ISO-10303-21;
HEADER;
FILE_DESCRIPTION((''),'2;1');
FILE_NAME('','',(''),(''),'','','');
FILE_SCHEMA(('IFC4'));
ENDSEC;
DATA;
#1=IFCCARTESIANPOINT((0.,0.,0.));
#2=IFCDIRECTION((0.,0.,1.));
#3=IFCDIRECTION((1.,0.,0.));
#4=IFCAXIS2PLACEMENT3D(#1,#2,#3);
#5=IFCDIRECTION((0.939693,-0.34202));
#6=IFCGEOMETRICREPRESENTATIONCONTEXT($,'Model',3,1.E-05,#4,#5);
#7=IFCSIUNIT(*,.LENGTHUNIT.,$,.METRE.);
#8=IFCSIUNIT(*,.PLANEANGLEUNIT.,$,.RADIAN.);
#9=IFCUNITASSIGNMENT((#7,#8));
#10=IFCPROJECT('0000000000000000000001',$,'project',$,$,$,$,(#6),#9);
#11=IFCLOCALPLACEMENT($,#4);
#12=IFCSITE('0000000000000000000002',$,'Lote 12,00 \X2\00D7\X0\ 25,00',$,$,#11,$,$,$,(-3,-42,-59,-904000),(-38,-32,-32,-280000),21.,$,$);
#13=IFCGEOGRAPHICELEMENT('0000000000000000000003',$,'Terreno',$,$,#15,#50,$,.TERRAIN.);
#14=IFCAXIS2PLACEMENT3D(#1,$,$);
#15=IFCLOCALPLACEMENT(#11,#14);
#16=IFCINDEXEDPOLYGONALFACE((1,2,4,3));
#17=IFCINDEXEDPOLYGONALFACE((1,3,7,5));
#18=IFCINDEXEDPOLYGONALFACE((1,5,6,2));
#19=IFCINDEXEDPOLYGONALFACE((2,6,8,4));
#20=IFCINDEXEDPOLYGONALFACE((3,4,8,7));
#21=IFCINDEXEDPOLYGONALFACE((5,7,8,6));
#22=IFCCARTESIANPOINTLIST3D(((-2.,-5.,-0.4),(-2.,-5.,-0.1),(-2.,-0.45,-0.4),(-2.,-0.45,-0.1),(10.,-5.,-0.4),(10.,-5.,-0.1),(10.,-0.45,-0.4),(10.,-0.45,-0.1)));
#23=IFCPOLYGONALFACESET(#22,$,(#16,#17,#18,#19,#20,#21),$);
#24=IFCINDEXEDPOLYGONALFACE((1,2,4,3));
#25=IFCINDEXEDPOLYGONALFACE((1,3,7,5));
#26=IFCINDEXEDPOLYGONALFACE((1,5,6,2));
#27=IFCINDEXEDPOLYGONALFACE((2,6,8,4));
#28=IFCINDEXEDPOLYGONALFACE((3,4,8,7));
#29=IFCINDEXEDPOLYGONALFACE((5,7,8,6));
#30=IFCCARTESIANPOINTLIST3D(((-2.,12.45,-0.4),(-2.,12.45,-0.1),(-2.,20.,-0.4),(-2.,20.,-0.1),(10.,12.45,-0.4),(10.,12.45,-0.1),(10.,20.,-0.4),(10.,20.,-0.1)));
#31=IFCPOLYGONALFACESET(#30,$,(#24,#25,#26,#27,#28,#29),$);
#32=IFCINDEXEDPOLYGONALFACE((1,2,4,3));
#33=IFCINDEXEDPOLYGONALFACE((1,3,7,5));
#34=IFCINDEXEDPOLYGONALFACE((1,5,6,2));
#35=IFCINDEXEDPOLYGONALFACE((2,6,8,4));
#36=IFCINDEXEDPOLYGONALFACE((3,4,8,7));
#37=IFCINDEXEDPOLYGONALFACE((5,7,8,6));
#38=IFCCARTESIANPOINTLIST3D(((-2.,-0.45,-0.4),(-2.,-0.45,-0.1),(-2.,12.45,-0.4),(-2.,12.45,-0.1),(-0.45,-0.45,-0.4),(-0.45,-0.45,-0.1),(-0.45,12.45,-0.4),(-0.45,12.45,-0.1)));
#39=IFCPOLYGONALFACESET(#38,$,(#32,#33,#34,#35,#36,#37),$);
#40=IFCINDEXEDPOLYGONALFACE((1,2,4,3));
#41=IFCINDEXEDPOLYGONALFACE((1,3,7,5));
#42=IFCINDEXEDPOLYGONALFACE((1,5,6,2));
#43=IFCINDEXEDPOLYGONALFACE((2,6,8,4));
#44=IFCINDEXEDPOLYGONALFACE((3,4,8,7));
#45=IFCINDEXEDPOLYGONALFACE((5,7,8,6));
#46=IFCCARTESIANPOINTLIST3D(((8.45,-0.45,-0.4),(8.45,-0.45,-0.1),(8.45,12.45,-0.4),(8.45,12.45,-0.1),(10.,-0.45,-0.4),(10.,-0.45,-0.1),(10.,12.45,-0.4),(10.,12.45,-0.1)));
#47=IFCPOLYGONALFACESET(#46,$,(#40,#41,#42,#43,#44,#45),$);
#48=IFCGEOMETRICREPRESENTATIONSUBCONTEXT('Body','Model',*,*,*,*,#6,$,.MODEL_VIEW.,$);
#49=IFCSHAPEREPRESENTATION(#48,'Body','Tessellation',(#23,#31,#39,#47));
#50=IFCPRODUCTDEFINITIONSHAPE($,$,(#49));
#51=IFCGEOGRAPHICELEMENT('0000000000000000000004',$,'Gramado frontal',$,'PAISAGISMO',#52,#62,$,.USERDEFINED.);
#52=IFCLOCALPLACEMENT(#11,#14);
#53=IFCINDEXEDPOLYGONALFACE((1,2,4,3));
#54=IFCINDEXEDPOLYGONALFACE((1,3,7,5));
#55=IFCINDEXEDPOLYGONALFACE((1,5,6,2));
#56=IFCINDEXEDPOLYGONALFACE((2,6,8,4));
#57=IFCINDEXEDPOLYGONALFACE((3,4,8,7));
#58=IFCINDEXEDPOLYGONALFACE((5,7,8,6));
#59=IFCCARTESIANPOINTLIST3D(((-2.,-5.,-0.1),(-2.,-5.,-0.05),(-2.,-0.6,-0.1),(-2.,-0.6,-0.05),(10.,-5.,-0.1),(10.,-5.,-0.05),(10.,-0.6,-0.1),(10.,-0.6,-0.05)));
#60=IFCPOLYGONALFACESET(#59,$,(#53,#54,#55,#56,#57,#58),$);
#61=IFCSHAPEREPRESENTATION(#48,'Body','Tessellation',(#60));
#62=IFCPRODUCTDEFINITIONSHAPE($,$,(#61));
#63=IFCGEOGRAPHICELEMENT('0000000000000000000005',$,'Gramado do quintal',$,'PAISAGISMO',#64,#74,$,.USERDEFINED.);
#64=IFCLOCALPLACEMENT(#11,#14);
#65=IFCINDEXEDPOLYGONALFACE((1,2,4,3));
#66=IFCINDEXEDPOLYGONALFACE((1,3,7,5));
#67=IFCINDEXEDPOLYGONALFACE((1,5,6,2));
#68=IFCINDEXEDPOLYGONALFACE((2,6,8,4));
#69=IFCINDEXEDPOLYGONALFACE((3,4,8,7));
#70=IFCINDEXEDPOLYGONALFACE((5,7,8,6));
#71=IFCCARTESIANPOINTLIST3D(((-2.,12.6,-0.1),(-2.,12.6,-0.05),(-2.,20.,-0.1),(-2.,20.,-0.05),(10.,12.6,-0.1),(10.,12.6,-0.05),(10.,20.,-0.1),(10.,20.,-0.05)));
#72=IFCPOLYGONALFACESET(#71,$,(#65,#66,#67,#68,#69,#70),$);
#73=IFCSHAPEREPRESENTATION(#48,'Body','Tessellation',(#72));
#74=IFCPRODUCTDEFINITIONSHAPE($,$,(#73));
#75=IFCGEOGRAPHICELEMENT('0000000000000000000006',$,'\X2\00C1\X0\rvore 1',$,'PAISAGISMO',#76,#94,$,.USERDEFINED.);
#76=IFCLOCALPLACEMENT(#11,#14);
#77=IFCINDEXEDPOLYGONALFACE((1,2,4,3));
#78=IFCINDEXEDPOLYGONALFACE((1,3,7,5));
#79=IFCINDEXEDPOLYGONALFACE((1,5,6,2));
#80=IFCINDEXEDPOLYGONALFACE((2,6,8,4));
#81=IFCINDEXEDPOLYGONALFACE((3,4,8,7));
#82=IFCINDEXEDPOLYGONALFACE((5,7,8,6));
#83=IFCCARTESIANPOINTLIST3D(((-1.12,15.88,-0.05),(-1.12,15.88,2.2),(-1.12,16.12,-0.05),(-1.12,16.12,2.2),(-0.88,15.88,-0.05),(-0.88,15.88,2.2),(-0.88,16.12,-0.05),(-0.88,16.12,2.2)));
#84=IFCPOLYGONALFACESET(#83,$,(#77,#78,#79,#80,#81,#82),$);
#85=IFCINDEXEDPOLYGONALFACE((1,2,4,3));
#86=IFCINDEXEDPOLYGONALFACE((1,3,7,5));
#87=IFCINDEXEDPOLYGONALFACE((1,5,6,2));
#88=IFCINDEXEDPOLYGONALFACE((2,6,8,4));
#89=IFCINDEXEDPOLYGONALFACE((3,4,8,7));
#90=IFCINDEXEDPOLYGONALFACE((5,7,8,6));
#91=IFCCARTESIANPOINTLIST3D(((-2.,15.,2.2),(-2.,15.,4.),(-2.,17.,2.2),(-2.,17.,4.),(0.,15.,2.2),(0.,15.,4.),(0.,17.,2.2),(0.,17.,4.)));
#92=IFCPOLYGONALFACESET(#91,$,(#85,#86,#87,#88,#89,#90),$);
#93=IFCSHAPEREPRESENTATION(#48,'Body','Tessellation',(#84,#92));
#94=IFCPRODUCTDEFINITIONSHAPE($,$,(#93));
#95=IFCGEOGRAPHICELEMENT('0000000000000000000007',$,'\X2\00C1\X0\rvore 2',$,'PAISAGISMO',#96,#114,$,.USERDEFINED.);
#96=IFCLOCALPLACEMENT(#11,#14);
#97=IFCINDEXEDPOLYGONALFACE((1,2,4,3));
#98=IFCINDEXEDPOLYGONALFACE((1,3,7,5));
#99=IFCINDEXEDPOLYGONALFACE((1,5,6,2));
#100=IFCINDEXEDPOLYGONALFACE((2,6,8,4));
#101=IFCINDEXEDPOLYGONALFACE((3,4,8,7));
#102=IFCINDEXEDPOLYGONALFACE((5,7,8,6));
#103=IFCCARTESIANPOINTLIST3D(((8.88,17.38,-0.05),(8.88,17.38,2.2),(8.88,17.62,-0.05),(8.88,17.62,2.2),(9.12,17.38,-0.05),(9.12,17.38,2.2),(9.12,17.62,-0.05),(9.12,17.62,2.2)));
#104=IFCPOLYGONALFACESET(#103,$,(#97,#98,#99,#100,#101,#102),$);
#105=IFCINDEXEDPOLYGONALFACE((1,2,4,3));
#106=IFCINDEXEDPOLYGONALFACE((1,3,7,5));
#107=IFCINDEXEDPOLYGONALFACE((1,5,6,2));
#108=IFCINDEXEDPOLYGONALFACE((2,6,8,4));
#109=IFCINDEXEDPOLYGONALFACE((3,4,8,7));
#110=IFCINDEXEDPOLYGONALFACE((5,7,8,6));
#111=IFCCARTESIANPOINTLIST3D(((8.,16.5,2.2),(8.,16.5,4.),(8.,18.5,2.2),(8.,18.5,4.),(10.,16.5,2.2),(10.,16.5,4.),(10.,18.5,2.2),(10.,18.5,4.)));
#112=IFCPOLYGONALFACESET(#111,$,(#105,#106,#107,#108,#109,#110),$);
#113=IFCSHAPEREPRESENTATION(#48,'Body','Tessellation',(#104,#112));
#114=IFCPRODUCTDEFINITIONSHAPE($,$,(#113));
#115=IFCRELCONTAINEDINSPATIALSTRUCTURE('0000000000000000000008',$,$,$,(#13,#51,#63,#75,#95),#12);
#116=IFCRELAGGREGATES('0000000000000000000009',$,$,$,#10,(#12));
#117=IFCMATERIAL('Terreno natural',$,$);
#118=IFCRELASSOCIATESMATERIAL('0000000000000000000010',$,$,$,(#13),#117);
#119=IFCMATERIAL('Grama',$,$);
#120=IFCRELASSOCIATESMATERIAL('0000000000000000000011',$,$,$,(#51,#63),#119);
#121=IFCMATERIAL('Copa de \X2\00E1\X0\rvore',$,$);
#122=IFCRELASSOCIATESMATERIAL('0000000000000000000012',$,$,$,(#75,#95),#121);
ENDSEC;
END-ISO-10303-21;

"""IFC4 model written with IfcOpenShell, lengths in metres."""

from ifc_helpers import new_model, si_unit, direction, frame, origin_with_axes, place, context, subcontext, project, spatial, line, indexed_curve, outline, extrude, material, element, save


model = new_model("IFC4")

# Units and contexts
model_context = context("Model", 3, precision=1e-05, world=origin_with_axes(), true_north=direction((0.939693, -0.34202)))
body_context = subcontext(model_context, "Body", "Model", "MODEL_VIEW")
ifc_project = project(units=[si_unit("LENGTHUNIT", "METRE"), si_unit("PLANEANGLEUNIT", "RADIAN")], contexts=[model_context])

# Site
site_placement = place(None, origin_with_axes())
site = spatial("IfcSite", under=ifc_project, at=site_placement, Name="Lote 12,00 × 25,00", RefLatitude=(-3, -42, -59, -904000), RefLongitude=(-38, -32, -32, -280000), RefElevation=21.0)

# Geographic elements
ifc_material_1 = material(Name="Terreno natural")
geographic_element_1_placement = place(site_placement, origin_with_axes())
element("IfcGeographicElement", 1, at=geographic_element_1_placement, inside=site, material=ifc_material_1, Name="Terreno", PredefinedType="TERRAIN", context=body_context, shape_type="SweptSolid", body=[
    extrude(outline(indexed_curve([(-2.0, -5.0), (10.0, -5.0), (10.0, -0.45), (-2.0, -0.45)], segments=[line(1, 2, 3, 4, 1)])), frame((0.0, 0.0, -0.4), z_axis=(0.0, 0.0, 1.0), x_axis=(1.0, 0.0, 0.0)), (0.0, 0.0, 1.0), 0.3),
    extrude(outline(indexed_curve([(-2.0, 12.45), (10.0, 12.45), (10.0, 20.0), (-2.0, 20.0)], segments=[line(1, 2, 3, 4, 1)])), frame((0.0, 0.0, -0.4), z_axis=(0.0, 0.0, 1.0), x_axis=(1.0, 0.0, 0.0)), (0.0, 0.0, 1.0), 0.3),
    extrude(outline(indexed_curve([(-2.0, -0.45), (-0.45, -0.45), (-0.45, 12.45), (-2.0, 12.45)], segments=[line(1, 2, 3, 4, 1)])), frame((0.0, 0.0, -0.4), z_axis=(0.0, 0.0, 1.0), x_axis=(1.0, 0.0, 0.0)), (0.0, 0.0, 1.0), 0.3),
    extrude(outline(indexed_curve([(8.45, -0.45), (10.0, -0.45), (10.0, 12.45), (8.45, 12.45)], segments=[line(1, 2, 3, 4, 1)])), frame((0.0, 0.0, -0.4), z_axis=(0.0, 0.0, 1.0), x_axis=(1.0, 0.0, 0.0)), (0.0, 0.0, 1.0), 0.3),
])
ifc_material_2 = material(Name="Grama")
geographic_element_2_placement = place(site_placement, origin_with_axes())
element("IfcGeographicElement", 2, at=geographic_element_2_placement, inside=site, material=ifc_material_2, Name="Gramado frontal", ObjectType="PAISAGISMO", PredefinedType="USERDEFINED", context=body_context, shape_type="SweptSolid", body=[
    extrude(outline(indexed_curve([(-2.0, -5.0), (10.0, -5.0), (10.0, -0.6), (-2.0, -0.6)], segments=[line(1, 2, 3, 4, 1)])), frame((0.0, 0.0, -0.1), z_axis=(0.0, 0.0, 1.0), x_axis=(1.0, 0.0, 0.0)), (0.0, 0.0, 1.0), 0.05),
])
geographic_element_3_placement = place(site_placement, origin_with_axes())
element("IfcGeographicElement", 3, at=geographic_element_3_placement, inside=site, material=ifc_material_2, Name="Gramado do quintal", ObjectType="PAISAGISMO", PredefinedType="USERDEFINED", context=body_context, shape_type="SweptSolid", body=[
    extrude(outline(indexed_curve([(-2.0, 12.6), (10.0, 12.6), (10.0, 20.0), (-2.0, 20.0)], segments=[line(1, 2, 3, 4, 1)])), frame((0.0, 0.0, -0.1), z_axis=(0.0, 0.0, 1.0), x_axis=(1.0, 0.0, 0.0)), (0.0, 0.0, 1.0), 0.05),
])
ifc_material_3 = material(Name="Copa de árvore")
geographic_element_4_placement = place(site_placement, origin_with_axes())
element("IfcGeographicElement", 4, at=geographic_element_4_placement, inside=site, material=ifc_material_3, Name="Árvore 1", ObjectType="PAISAGISMO", PredefinedType="USERDEFINED", context=body_context, shape_type="SweptSolid", body=[
    extrude(outline(indexed_curve([(-1.12, 15.88), (-0.88, 15.88), (-0.88, 16.12), (-1.12, 16.12)], segments=[line(1, 2, 3, 4, 1)])), frame((0.0, 0.0, -0.05), z_axis=(0.0, 0.0, 1.0), x_axis=(1.0, 0.0, 0.0)), (0.0, 0.0, 1.0), 2.25),
    extrude(outline(indexed_curve([(-2.0, 15.0), (0.0, 15.0), (0.0, 17.0), (-2.0, 17.0)], segments=[line(1, 2, 3, 4, 1)])), frame((0.0, 0.0, 2.2), z_axis=(0.0, 0.0, 1.0), x_axis=(1.0, 0.0, 0.0)), (0.0, 0.0, 1.0), 1.8),
])
geographic_element_5_placement = place(site_placement, origin_with_axes())
element("IfcGeographicElement", 5, at=geographic_element_5_placement, inside=site, material=ifc_material_3, Name="Árvore 2", ObjectType="PAISAGISMO", PredefinedType="USERDEFINED", context=body_context, shape_type="SweptSolid", body=[
    extrude(outline(indexed_curve([(8.88, 17.38), (9.12, 17.38), (9.12, 17.62), (8.88, 17.62)], segments=[line(1, 2, 3, 4, 1)])), frame((0.0, 0.0, -0.05), z_axis=(0.0, 0.0, 1.0), x_axis=(1.0, 0.0, 0.0)), (0.0, 0.0, 1.0), 2.25),
    extrude(outline(indexed_curve([(8.0, 16.5), (10.0, 16.5), (10.0, 18.5), (8.0, 18.5)], segments=[line(1, 2, 3, 4, 1)])), frame((0.0, 0.0, 2.2), z_axis=(0.0, 0.0, 1.0), x_axis=(1.0, 0.0, 0.0)), (0.0, 0.0, 1.0), 1.8),
])

save(model, "model.ifc")
